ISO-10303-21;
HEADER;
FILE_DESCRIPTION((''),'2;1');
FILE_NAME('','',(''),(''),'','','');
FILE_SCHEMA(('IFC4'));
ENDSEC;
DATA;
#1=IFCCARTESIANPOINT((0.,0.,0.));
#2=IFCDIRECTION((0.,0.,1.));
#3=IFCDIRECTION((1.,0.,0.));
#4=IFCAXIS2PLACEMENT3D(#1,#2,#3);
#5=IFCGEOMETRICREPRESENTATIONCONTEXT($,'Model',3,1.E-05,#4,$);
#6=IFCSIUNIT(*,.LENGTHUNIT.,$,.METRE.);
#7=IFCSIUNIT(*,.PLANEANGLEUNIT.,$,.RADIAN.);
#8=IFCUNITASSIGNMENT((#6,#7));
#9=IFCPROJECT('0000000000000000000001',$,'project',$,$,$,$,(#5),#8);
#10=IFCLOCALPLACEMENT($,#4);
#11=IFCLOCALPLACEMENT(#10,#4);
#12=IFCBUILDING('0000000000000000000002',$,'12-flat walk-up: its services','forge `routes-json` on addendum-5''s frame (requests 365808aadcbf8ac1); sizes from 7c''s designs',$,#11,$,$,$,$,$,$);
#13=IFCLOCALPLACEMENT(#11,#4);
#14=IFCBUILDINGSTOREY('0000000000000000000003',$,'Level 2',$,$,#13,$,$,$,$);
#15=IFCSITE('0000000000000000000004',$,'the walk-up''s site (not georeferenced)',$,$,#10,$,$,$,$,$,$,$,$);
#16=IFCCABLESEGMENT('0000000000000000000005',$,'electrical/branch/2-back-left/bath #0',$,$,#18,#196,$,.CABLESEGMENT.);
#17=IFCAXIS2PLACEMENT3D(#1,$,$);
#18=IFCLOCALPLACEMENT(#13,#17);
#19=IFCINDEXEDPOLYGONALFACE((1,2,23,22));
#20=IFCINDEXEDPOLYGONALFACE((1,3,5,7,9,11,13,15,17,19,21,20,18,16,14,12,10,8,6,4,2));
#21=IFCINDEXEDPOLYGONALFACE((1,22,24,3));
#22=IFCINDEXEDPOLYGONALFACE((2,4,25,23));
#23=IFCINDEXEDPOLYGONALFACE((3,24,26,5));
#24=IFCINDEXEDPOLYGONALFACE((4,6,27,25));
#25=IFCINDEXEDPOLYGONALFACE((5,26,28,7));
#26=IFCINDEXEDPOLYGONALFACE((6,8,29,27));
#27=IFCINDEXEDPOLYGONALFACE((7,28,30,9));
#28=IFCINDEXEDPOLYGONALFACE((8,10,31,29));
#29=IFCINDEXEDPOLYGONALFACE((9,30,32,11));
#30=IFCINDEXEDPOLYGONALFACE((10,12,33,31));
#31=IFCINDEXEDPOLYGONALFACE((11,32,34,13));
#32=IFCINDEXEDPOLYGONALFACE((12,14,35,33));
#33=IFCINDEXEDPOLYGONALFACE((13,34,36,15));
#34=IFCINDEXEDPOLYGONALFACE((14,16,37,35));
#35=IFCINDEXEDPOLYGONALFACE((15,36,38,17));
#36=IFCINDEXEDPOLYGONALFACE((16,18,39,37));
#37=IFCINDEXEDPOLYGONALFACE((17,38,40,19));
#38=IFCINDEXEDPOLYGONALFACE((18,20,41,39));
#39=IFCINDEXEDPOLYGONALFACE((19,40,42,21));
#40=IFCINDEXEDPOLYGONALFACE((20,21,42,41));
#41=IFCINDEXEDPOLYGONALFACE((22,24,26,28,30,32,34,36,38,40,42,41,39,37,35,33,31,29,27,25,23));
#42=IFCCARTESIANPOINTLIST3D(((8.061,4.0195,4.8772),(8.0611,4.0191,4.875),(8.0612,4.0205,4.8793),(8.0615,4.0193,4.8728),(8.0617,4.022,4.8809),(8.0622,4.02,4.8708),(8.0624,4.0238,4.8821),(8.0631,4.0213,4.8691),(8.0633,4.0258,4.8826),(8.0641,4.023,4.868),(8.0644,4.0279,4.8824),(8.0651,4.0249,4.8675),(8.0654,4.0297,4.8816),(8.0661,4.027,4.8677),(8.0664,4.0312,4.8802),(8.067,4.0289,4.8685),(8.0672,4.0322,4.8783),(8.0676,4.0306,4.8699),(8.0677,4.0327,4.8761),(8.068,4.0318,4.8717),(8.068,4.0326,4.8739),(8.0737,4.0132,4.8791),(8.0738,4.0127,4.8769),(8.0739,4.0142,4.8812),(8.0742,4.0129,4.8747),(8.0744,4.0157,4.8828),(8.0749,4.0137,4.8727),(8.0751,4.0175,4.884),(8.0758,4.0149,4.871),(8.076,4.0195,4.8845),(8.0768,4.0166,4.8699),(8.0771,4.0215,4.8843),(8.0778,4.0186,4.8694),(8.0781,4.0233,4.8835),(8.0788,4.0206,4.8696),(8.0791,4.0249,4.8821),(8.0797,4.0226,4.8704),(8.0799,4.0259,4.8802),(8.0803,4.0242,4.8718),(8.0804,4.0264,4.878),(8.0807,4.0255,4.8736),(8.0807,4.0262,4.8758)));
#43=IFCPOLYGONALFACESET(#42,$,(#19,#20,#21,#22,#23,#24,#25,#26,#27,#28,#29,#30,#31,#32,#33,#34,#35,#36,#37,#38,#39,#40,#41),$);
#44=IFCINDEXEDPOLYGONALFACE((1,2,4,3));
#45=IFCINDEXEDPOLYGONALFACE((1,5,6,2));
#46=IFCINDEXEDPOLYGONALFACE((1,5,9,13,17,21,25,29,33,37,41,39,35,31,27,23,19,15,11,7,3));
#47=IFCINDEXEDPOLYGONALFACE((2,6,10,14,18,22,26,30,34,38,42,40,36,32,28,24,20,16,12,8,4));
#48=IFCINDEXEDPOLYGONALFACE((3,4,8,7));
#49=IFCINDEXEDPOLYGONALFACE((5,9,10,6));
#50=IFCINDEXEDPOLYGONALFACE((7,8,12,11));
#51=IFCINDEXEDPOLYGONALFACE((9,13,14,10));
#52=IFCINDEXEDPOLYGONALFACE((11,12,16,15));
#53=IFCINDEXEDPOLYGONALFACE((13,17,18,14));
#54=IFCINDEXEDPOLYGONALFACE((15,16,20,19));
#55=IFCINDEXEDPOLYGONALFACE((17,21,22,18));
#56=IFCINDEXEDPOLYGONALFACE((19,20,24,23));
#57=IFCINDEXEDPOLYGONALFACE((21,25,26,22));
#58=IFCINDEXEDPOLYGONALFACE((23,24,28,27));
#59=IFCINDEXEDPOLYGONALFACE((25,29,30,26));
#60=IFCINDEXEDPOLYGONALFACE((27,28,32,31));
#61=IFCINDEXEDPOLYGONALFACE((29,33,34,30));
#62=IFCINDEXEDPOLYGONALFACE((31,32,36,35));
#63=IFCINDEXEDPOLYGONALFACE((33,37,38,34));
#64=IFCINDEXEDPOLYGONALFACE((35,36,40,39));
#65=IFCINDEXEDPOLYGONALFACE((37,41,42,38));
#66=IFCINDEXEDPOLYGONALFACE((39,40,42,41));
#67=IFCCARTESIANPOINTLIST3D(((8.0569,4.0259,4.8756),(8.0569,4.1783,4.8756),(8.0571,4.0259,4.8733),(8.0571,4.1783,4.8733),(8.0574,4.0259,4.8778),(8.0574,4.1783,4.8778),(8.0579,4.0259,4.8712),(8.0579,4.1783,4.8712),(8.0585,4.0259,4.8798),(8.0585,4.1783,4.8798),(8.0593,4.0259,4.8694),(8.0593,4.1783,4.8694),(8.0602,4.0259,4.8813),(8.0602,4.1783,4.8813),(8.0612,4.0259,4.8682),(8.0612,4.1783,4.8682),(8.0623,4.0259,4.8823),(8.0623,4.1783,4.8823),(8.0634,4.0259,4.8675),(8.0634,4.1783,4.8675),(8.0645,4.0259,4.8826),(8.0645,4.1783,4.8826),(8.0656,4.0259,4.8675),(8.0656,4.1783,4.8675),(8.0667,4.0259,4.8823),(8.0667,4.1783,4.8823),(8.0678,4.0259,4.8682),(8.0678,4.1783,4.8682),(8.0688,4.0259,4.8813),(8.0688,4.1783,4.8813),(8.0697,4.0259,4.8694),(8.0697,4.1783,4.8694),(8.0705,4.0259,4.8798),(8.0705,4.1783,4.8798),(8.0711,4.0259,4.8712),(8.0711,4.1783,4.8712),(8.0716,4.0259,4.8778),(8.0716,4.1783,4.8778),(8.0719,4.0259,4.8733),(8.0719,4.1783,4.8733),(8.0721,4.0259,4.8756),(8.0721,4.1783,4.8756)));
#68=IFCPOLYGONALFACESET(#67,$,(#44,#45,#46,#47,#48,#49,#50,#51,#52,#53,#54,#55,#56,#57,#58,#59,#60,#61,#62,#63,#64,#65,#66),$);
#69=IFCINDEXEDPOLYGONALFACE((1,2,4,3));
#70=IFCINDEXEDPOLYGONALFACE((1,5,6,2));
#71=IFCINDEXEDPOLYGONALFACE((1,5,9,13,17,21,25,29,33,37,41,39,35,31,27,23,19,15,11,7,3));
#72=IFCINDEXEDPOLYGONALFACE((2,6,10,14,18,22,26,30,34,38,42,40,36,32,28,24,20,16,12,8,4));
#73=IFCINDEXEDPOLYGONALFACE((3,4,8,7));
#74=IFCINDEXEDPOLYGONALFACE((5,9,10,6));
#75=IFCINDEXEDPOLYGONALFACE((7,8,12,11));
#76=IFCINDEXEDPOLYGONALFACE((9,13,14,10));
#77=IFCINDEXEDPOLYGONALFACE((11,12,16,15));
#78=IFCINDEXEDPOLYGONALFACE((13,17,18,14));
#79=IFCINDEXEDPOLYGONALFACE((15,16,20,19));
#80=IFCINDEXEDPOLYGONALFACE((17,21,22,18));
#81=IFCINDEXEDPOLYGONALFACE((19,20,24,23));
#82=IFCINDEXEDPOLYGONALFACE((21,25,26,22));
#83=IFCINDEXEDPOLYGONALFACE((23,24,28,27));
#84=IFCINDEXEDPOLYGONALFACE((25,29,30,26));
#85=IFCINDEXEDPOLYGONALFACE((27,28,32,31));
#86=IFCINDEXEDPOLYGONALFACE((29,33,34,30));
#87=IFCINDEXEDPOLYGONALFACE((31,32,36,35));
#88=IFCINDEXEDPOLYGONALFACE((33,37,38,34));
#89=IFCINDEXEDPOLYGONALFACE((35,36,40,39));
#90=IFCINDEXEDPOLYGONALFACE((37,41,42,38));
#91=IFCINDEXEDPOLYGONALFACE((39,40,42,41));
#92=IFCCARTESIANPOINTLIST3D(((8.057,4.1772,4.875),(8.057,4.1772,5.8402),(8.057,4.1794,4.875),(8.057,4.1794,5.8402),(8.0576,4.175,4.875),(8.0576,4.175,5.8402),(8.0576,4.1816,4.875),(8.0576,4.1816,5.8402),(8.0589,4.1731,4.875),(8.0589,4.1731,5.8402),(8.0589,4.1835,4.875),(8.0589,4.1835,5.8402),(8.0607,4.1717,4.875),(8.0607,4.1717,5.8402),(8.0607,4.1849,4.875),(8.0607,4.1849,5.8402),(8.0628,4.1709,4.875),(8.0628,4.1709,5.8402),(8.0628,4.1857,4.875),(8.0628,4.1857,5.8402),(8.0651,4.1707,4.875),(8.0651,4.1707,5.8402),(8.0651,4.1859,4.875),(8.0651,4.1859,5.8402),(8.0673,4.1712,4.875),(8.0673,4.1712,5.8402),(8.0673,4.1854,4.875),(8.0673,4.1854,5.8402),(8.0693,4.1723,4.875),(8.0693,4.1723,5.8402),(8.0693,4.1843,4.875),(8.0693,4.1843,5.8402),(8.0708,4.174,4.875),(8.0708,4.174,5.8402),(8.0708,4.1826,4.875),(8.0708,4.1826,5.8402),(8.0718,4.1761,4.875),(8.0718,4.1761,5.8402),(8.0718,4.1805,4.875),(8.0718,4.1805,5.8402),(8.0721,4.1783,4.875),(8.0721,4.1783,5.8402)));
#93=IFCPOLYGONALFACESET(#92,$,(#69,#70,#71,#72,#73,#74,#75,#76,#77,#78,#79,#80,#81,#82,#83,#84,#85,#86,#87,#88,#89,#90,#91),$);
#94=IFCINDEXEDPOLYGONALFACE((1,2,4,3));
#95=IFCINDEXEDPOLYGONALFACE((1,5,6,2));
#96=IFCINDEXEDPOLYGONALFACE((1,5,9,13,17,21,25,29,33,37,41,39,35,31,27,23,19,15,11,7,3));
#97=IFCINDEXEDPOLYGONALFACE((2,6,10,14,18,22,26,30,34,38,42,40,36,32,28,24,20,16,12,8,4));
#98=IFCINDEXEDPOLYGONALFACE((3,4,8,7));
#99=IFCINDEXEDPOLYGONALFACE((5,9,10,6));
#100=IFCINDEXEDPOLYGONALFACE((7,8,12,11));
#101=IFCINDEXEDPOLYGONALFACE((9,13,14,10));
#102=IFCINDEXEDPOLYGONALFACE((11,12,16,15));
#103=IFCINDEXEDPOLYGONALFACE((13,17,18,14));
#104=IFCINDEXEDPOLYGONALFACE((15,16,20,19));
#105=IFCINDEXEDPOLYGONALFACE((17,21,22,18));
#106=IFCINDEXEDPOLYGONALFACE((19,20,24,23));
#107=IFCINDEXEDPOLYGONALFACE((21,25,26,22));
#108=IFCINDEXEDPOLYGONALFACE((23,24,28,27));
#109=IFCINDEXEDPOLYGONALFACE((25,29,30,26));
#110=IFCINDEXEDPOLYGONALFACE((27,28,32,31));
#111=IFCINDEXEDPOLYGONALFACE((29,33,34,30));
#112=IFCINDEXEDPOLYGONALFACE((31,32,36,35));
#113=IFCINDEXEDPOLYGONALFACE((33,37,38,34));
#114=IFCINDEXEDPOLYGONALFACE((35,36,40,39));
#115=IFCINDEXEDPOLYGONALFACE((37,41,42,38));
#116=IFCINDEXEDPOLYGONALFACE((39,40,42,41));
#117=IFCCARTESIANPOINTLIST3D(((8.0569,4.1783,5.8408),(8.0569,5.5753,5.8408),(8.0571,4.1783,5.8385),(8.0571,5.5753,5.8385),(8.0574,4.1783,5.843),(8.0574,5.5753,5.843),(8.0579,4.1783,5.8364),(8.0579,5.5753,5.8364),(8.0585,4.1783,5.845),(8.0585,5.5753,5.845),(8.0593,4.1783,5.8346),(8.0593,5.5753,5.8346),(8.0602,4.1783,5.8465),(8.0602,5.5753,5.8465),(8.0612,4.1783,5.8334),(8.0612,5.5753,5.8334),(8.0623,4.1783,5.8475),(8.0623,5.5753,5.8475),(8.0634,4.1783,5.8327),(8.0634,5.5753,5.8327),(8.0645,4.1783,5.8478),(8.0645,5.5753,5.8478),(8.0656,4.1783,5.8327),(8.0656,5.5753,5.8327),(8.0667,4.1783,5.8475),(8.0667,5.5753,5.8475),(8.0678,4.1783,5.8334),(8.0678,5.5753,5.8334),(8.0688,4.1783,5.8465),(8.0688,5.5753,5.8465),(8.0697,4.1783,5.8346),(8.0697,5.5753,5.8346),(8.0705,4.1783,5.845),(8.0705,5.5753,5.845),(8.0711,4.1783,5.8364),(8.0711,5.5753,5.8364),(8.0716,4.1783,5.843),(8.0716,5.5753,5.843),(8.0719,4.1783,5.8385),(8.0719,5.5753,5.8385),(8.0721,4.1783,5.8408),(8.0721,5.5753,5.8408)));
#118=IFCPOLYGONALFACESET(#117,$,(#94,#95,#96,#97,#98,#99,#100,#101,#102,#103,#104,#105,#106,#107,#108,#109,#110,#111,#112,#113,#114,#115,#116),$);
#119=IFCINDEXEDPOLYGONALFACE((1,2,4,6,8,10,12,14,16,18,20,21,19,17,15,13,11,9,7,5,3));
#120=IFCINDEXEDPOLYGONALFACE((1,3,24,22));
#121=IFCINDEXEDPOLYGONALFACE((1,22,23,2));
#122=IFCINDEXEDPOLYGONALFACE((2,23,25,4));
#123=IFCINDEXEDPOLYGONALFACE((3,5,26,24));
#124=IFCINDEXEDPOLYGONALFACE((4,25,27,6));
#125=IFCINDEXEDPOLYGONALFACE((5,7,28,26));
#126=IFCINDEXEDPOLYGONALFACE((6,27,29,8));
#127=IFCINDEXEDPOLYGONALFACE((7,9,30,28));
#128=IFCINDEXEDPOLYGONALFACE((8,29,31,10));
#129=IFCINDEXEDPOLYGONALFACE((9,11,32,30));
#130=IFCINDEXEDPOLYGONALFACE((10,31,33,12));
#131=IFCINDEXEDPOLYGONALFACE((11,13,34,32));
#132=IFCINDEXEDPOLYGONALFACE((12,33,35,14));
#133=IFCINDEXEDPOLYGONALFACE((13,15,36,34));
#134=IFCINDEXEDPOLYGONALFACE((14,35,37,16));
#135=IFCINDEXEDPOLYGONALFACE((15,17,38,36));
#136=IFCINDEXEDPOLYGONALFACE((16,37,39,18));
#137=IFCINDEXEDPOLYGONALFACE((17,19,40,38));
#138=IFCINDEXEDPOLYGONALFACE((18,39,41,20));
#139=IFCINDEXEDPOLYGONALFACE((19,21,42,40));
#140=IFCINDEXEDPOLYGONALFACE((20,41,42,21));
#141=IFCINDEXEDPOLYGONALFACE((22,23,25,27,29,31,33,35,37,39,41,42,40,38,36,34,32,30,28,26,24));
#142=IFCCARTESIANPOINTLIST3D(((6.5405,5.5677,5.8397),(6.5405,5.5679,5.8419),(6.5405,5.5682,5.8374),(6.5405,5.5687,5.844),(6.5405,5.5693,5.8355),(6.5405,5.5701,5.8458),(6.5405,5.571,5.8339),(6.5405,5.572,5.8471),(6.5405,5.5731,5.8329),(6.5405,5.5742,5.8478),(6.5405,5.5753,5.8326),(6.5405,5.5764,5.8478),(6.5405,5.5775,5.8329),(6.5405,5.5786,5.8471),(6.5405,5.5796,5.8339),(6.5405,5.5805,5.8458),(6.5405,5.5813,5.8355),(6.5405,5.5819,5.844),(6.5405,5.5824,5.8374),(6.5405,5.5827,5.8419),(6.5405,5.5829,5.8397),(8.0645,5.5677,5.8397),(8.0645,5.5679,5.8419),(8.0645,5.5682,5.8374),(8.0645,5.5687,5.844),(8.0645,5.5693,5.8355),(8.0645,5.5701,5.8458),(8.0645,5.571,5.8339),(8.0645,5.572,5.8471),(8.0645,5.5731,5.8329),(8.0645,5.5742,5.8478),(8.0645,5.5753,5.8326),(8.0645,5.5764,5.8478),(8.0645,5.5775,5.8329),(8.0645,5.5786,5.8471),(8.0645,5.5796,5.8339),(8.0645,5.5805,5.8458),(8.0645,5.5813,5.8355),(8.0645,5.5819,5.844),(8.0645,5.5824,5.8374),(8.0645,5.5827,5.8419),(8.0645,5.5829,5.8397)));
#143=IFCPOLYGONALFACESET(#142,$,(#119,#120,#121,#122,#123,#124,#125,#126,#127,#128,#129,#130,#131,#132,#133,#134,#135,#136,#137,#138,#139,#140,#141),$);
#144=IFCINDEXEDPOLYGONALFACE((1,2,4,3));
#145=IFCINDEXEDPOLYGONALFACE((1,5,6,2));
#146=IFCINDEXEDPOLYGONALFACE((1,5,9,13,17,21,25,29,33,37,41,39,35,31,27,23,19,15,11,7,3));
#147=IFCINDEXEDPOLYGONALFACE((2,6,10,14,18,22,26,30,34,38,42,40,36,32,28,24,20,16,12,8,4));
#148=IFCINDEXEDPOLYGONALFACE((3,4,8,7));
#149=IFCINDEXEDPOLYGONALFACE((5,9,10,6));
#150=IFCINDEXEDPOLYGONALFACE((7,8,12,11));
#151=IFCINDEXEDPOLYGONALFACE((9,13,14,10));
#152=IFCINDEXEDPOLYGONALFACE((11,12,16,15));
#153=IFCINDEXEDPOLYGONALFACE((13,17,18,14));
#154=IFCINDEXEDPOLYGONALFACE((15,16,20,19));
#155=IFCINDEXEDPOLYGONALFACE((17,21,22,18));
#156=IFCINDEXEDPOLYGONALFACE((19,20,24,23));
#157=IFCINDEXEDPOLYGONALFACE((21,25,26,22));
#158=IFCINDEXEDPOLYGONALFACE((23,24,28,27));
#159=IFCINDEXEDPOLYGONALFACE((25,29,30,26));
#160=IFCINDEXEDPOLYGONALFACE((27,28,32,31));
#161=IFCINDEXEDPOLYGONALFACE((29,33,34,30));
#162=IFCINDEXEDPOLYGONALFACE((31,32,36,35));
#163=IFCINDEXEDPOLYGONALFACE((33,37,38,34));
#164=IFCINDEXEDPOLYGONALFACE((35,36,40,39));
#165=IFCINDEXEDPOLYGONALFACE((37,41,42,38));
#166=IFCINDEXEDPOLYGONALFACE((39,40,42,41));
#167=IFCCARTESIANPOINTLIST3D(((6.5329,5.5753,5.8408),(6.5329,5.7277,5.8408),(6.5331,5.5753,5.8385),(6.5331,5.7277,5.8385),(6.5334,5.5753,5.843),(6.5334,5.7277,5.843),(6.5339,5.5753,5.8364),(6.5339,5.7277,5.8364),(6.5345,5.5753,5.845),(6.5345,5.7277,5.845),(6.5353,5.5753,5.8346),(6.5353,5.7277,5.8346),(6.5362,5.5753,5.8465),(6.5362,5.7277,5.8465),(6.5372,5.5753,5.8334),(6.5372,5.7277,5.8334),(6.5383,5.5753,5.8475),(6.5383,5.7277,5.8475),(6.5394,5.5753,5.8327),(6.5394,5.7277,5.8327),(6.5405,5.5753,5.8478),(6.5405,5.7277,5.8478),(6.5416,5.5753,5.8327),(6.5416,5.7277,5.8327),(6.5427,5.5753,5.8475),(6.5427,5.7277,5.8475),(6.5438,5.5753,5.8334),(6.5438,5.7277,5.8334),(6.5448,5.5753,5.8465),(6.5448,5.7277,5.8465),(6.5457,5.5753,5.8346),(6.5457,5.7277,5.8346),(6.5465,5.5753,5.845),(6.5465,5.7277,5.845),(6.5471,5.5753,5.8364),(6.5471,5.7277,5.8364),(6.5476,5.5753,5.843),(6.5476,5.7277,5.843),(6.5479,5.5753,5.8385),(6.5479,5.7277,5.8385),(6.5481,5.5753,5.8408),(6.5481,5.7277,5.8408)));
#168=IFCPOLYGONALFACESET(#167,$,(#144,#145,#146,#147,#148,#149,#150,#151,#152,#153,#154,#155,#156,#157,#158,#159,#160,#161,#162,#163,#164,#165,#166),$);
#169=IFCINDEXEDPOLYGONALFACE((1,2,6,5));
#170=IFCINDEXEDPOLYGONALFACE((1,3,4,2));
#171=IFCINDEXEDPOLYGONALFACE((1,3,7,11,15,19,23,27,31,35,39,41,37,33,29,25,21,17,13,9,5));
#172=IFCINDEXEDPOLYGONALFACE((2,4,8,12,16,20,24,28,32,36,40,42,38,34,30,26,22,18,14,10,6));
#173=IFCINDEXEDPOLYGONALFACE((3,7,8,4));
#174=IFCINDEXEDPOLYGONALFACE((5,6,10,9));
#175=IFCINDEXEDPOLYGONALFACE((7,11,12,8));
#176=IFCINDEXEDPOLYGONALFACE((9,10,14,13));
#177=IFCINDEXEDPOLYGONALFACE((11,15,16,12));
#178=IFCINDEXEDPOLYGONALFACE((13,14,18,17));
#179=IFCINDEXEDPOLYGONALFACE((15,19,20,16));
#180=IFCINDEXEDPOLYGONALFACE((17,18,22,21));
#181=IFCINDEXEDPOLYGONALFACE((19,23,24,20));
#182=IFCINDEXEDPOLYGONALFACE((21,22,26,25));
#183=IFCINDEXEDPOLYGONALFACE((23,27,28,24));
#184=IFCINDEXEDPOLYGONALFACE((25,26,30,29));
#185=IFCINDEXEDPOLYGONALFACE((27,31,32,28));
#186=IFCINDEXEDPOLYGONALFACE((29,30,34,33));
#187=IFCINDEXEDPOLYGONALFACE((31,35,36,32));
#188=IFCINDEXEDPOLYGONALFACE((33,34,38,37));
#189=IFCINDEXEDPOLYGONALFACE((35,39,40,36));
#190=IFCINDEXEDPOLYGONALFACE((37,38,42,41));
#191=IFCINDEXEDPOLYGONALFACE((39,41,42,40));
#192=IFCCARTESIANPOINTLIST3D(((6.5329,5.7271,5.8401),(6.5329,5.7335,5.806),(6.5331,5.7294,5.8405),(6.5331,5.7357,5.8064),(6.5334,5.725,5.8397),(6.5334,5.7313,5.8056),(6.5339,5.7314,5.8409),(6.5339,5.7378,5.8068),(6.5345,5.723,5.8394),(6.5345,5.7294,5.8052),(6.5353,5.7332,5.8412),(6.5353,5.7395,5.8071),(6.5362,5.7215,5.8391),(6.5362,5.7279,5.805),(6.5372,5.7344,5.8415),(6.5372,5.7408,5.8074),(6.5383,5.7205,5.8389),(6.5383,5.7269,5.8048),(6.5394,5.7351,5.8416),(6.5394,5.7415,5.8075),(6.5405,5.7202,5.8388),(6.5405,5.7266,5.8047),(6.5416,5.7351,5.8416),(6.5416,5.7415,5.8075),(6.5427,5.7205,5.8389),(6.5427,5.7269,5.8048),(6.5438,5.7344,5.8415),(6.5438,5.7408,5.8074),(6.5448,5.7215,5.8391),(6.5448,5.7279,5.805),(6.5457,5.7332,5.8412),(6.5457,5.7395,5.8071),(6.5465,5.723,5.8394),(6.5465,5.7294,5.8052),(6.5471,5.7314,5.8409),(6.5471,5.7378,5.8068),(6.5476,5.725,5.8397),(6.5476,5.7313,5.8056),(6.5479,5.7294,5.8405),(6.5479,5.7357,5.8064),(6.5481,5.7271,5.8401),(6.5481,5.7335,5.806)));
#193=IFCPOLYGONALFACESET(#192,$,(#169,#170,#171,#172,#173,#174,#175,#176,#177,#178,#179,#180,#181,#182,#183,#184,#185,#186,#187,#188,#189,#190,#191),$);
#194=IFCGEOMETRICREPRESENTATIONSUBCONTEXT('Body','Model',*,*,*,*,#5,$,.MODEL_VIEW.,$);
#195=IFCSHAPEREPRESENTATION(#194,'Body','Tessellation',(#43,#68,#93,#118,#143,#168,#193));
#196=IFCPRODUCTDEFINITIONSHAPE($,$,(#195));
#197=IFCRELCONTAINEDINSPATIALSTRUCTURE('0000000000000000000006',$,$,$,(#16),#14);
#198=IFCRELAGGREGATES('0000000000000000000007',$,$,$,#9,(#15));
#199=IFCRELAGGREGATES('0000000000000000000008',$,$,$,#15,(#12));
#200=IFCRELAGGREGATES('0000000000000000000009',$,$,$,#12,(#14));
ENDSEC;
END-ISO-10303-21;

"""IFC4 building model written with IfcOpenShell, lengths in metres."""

from ifc_helpers import new_model, entity, si_unit, frame, origin_with_axes, place, context, subcontext, project, spatial, element, save


model = new_model("IFC4")

# Units and contexts
model_context = context("Model", 3, precision=1e-05, world=origin_with_axes())
body_context = subcontext(model_context, "Body", "Model", "MODEL_VIEW")
ifc_project = project(units=[si_unit("LENGTHUNIT", "METRE"), si_unit("PLANEANGLEUNIT", "RADIAN")], contexts=[model_context])

# Site, building, storey
site_placement = place(None, origin_with_axes())
site = spatial("IfcSite", under=ifc_project, at=site_placement, Name="the walk-up's site (not georeferenced)")
building_placement = place(site_placement, origin_with_axes())
building = spatial("IfcBuilding", under=site, at=building_placement, Name="12-flat walk-up: its services", Description="forge `routes-json` on addendum-5's frame (requests 365808aadcbf8ac1); sizes from 7c's designs")
storey_placement = place(building_placement, origin_with_axes())
storey = spatial("IfcBuildingStorey", under=building, at=storey_placement, Name="Level 2")

# Cable segment
cable_segment_1_placement = place(storey_placement, frame((8.0772, 4.0195, 4.8769), z_axis=(0.0, 0.0, 1.0), x_axis=(1.0, 0.0, 0.0)))
element("IfcCableSegment", 1, at=cable_segment_1_placement, inside=storey, Name="electrical/branch/2-back-left/bath #0", PredefinedType="CABLESEGMENT", context=body_context, shape_type="AdvancedSweptSolid", body=[
    entity("IfcSweptDiskSolid", entity("IfcPolyline", [entity("IfcCartesianPoint", [0.0, 0.0, 0.0]), entity("IfcCartesianPoint", [-0.0127, 0.0064, -0.0019])]), 0.0076),
    entity("IfcSweptDiskSolid", entity("IfcPolyline", [entity("IfcCartesianPoint", [-0.0127, 0.0064, -0.0019]), entity("IfcCartesianPoint", [-0.0127, 0.1588, -0.0019])]), 0.0076),
    entity("IfcSweptDiskSolid", entity("IfcPolyline", [entity("IfcCartesianPoint", [-0.0127, 0.1588, -0.0019]), entity("IfcCartesianPoint", [-0.0127, 0.1588, 0.9633])]), 0.0076),
    entity("IfcSweptDiskSolid", entity("IfcPolyline", [entity("IfcCartesianPoint", [-0.0127, 0.1588, 0.9633]), entity("IfcCartesianPoint", [-0.0127, 1.5557, 0.9633])]), 0.0076),
    entity("IfcSweptDiskSolid", entity("IfcPolyline", [entity("IfcCartesianPoint", [-0.0127, 1.5557, 0.9633]), entity("IfcCartesianPoint", [-1.5367, 1.5557, 0.9633])]), 0.0076),
    entity("IfcSweptDiskSolid", entity("IfcPolyline", [entity("IfcCartesianPoint", [-1.5367, 1.5557, 0.9633]), entity("IfcCartesianPoint", [-1.5367, 1.7081, 0.9633])]), 0.0076),
    entity("IfcSweptDiskSolid", entity("IfcPolyline", [entity("IfcCartesianPoint", [-1.5367, 1.7081, 0.9633]), entity("IfcCartesianPoint", [-1.5367, 1.7145, 0.9292])]), 0.0076),
])

save(model, "model.ifc")
